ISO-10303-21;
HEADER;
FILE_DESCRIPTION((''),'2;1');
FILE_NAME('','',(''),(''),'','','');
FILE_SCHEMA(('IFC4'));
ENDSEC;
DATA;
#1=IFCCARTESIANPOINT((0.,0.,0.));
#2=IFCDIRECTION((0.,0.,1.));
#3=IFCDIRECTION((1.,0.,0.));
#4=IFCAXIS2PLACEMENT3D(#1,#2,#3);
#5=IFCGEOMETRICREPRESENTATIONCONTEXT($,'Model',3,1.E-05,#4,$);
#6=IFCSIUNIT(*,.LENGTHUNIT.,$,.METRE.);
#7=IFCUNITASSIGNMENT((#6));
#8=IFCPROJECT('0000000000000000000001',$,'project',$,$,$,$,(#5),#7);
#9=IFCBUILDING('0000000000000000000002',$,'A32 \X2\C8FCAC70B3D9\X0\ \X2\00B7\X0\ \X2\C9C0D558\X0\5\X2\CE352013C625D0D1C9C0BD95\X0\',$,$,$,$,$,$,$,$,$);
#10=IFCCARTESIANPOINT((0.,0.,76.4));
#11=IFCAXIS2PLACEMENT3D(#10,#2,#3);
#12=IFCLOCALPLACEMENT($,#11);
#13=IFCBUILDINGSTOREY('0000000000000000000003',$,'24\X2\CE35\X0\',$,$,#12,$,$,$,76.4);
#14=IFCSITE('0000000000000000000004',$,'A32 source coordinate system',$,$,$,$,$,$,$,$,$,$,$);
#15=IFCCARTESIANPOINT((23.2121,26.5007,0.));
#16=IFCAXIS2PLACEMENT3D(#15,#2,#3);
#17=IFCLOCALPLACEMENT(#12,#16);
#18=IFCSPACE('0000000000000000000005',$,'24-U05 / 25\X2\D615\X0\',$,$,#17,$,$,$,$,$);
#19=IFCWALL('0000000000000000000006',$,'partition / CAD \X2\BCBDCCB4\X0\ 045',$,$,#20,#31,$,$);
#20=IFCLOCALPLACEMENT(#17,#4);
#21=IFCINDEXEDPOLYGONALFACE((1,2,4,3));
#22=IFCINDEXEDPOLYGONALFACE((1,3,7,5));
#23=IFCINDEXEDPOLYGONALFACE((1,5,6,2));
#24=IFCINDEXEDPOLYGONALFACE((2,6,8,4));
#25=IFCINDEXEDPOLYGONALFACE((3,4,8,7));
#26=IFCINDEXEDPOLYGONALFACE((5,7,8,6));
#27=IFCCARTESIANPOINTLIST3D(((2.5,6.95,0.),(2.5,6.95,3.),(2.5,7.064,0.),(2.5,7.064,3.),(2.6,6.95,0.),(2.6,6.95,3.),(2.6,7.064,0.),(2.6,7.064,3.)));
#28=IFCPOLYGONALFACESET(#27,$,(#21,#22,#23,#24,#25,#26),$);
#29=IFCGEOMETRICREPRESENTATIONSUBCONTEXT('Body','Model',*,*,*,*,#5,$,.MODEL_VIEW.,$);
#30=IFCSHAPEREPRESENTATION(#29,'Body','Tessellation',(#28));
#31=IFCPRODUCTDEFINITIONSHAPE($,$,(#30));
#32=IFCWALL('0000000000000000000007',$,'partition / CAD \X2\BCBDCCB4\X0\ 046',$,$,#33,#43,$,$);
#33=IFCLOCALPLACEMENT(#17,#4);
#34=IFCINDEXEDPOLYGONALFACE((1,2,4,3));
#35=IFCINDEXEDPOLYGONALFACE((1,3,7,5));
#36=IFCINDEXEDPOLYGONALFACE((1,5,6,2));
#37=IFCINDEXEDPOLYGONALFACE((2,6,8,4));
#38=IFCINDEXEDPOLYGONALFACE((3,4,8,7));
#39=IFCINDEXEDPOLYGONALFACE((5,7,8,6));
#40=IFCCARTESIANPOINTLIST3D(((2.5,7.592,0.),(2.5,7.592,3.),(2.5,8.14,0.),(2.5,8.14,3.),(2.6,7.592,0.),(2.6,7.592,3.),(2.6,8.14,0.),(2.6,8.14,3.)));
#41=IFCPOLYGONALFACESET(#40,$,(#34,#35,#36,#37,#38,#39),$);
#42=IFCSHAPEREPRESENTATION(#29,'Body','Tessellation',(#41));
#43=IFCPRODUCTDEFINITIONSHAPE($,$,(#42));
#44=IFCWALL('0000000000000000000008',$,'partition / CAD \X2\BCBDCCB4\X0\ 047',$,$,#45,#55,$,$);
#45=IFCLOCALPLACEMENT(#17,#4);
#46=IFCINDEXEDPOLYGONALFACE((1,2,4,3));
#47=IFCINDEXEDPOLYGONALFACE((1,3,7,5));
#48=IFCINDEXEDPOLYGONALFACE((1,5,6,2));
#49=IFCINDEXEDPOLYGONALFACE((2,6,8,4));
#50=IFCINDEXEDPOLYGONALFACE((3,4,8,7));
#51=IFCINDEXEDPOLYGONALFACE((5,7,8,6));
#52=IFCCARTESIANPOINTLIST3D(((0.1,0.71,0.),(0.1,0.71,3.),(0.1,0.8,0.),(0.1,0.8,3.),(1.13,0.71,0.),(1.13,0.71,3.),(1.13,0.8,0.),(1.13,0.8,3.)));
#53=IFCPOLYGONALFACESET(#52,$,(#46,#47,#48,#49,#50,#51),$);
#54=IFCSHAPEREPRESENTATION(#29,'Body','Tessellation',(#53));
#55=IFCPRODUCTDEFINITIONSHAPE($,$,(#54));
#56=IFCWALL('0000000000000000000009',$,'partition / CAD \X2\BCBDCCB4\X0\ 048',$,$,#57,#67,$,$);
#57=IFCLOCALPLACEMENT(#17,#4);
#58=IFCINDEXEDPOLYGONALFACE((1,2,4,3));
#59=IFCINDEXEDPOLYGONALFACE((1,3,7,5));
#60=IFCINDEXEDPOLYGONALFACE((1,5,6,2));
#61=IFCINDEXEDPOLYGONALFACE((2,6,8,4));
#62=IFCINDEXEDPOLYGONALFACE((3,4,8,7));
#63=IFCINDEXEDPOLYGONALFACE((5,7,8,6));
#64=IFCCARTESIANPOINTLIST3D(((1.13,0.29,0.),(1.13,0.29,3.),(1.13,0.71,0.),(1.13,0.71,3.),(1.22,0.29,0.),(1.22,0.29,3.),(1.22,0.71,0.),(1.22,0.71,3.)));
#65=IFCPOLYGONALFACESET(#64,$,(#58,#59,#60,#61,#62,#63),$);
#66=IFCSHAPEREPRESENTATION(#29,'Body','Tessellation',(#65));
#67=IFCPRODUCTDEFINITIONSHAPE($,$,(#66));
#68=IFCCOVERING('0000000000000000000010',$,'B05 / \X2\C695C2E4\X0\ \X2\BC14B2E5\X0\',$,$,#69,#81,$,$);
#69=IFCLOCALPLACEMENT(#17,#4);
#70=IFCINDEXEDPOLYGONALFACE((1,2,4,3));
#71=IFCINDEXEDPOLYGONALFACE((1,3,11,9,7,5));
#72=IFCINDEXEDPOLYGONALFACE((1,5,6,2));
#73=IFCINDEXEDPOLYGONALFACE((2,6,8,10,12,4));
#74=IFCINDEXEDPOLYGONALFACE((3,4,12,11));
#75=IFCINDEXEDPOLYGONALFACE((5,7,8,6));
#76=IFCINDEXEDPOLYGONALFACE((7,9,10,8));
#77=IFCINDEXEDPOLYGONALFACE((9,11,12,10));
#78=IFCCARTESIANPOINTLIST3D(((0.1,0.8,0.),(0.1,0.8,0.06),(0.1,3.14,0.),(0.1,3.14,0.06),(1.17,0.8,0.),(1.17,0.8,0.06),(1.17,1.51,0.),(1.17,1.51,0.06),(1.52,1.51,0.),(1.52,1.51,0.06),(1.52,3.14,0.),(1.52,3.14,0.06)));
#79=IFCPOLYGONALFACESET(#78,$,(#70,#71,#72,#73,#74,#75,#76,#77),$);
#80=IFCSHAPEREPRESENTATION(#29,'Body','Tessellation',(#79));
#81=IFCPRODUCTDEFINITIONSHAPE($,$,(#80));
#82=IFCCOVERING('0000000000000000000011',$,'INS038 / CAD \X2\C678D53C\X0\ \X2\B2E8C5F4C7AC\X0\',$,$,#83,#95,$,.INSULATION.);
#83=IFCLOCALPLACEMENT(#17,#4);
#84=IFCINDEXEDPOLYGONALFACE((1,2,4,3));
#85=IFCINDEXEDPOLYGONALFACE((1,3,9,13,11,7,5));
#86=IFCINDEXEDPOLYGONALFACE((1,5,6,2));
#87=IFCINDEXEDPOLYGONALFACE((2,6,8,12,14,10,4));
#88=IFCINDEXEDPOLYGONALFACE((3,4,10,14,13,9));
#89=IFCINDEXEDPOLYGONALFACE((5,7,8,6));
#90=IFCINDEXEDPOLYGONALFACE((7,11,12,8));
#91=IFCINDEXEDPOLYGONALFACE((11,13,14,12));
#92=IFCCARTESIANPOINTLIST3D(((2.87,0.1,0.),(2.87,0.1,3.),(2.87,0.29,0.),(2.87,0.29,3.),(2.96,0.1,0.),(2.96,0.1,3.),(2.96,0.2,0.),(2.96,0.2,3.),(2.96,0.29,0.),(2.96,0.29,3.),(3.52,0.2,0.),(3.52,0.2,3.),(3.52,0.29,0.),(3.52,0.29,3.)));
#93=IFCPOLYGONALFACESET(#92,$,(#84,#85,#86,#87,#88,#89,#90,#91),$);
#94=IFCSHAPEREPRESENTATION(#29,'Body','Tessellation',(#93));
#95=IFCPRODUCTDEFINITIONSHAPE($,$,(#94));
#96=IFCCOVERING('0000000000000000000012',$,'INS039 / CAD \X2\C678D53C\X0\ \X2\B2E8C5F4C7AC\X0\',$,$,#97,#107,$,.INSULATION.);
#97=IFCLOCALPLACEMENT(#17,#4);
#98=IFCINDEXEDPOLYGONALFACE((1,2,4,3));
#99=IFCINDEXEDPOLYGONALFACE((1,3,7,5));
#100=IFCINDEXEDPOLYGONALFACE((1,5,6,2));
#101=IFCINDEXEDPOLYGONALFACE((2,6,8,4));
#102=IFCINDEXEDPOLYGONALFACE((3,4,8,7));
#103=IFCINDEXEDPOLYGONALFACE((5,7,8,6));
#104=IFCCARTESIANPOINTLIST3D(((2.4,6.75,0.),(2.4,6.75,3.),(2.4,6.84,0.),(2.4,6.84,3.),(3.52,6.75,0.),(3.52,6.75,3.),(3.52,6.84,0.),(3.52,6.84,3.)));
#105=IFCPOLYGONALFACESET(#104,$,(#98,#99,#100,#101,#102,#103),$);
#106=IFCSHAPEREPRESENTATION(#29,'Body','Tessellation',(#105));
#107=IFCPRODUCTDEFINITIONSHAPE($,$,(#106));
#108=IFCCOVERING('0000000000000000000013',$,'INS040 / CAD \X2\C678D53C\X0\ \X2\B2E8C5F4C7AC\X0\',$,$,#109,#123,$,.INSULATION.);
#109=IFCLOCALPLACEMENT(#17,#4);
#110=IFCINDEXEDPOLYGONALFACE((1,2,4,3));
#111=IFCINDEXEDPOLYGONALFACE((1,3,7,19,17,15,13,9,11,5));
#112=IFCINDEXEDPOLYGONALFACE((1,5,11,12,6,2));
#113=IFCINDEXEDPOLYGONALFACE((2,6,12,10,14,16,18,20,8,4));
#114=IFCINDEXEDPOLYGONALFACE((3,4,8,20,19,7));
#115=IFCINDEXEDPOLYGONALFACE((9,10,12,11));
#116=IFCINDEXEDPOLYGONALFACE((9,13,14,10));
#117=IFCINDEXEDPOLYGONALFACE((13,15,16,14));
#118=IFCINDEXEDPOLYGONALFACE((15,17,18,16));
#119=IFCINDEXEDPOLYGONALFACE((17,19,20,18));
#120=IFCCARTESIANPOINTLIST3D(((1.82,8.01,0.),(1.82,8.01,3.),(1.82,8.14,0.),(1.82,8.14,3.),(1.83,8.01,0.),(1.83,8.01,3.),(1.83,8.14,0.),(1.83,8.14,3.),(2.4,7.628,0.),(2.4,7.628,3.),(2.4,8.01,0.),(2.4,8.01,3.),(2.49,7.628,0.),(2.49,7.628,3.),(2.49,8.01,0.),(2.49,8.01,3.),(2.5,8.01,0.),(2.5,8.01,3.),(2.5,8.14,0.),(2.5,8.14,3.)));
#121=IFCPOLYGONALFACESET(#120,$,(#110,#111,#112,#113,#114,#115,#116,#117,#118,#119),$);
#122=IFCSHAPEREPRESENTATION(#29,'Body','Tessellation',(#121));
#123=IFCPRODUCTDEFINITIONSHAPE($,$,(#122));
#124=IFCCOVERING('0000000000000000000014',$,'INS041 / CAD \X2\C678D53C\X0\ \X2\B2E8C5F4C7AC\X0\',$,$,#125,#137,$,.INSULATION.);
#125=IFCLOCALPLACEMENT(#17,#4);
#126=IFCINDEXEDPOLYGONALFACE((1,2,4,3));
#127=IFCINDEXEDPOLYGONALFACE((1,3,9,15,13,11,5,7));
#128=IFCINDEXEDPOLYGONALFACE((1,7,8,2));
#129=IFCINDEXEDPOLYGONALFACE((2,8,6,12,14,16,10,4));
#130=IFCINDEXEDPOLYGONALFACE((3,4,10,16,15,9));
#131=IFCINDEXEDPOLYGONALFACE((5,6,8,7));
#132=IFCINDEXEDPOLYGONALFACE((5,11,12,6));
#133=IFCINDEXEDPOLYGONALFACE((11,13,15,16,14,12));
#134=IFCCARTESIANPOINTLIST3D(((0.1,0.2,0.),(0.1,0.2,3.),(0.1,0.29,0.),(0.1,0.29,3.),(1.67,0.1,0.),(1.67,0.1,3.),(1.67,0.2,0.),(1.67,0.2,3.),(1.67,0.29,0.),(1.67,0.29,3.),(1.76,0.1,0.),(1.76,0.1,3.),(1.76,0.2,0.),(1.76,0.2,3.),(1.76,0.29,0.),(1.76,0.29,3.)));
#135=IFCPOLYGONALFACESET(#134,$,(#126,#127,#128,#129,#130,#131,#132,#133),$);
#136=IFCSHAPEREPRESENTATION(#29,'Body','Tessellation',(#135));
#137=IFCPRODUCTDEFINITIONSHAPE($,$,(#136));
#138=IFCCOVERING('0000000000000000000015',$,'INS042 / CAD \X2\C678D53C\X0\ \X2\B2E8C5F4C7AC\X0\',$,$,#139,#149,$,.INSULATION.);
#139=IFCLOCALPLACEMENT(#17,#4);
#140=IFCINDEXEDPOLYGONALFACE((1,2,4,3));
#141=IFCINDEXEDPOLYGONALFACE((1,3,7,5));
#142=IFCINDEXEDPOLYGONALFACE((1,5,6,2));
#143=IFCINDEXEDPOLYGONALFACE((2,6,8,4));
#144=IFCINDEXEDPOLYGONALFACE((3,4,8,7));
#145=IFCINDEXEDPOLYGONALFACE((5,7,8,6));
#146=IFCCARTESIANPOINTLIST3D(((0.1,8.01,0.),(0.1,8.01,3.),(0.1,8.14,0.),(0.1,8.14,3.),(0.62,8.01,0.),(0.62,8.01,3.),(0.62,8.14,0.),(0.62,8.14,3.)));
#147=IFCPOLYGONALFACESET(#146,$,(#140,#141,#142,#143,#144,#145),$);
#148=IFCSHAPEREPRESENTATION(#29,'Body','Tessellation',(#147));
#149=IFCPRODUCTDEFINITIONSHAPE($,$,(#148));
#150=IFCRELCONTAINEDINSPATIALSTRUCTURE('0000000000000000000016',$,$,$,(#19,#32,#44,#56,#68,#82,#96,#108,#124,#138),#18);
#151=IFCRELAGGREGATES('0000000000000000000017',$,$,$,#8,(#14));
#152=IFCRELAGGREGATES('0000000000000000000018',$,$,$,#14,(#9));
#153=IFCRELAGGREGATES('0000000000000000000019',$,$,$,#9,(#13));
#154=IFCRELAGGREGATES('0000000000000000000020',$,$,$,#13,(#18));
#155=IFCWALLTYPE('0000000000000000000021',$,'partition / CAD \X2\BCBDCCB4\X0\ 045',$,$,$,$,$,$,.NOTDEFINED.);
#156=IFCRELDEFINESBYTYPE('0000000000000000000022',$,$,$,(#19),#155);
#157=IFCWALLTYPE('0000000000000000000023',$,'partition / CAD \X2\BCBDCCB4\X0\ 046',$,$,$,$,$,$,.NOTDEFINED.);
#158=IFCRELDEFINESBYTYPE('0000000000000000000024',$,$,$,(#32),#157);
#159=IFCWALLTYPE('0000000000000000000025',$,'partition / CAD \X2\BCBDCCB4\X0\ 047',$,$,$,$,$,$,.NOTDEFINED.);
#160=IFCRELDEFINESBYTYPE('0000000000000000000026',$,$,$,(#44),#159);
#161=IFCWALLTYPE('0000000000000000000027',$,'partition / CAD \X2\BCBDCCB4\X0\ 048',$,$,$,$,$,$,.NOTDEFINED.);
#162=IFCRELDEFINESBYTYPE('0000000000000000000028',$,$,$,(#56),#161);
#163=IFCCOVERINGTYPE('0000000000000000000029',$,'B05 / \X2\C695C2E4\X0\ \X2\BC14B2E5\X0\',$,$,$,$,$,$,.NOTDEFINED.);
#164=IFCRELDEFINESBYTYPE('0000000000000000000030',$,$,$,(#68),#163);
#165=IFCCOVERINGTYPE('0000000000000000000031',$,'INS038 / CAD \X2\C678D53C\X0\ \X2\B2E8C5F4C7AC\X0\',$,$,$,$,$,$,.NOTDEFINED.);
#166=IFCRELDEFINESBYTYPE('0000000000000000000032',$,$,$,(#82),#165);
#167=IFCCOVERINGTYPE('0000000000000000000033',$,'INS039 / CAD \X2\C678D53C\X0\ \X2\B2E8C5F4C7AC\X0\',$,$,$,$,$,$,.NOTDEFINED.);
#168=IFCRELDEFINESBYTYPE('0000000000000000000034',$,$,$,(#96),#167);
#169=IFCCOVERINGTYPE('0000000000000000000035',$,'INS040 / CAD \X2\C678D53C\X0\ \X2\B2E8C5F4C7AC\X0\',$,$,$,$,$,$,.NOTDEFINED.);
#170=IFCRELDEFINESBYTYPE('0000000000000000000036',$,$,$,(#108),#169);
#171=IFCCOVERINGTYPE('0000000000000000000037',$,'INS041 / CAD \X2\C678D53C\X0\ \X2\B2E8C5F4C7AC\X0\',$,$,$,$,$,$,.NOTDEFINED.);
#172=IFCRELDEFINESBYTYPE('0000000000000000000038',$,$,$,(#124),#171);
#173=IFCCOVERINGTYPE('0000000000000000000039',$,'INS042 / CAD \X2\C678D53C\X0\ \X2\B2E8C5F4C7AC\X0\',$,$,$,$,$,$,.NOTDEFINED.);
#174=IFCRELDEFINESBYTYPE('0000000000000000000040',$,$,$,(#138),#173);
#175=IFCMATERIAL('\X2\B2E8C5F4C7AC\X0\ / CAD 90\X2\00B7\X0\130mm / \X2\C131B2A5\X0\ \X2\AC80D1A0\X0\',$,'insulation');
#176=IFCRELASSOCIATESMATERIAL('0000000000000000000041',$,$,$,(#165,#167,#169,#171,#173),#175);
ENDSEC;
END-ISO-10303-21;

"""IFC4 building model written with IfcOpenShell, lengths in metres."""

from ifc_helpers import new_model, si_unit, frame, origin, origin_with_axes, place, context, subcontext, project, spatial, polyline, outline, extrude, source, transform, mapped, material, type_object, type_shapes, element, save


model = new_model("IFC4")

# Units and contexts
model_context = context("Model", 3, precision=1e-05, world=origin_with_axes())
body_context = subcontext(model_context, "Body", "Model", "MODEL_VIEW")
ifc_project = project(units=[si_unit("LENGTHUNIT", "METRE")], contexts=[model_context])

# Site, building, storey, space
storey_placement = place(None, frame((0.0, 0.0, 76.4), z_axis=(0.0, 0.0, 1.0), x_axis=(1.0, 0.0, 0.0)))
space_placement = place(storey_placement, frame((23.2121, 26.5007, 0.0), z_axis=(0.0, 0.0, 1.0), x_axis=(1.0, 0.0, 0.0)))
site = spatial("IfcSite", under=ifc_project, Name="A32 source coordinate system")
building = spatial("IfcBuilding", under=site, Name="A32 주거동 · 지하5층–옥탑지붕")
storey = spatial("IfcBuildingStorey", under=building, at=storey_placement, Name="24층", Elevation=76.4)
space = spatial("IfcSpace", under=storey, at=space_placement, Name="24-U05 / 25형")

# Walls
wall_type_1 = type_object("IfcWallType", Name="partition / CAD 벽체 045", PredefinedType="NOTDEFINED")
shared_shape_1 = source(origin(), body_context, "Body", "SweptSolid", [
    extrude(outline(polyline([(2.5, 7.064), (2.6, 7.064), (2.6, 6.95), (2.5, 6.95), (2.5, 7.064)])), origin(), (0.0, 0.0, 1.0), 3.0),
])
type_shapes(wall_type_1, [shared_shape_1])
wall_1_placement = place(space_placement, origin_with_axes())
element("IfcWall", 1, at=wall_1_placement, inside=space, type_object=wall_type_1, Name="partition / CAD 벽체 045", context=body_context, shape_type="MappedRepresentation", body=[
    mapped(shared_shape_1, transform((0.0, 0.0, 0.0), scale=1.0)),
])
wall_type_2 = type_object("IfcWallType", Name="partition / CAD 벽체 046", PredefinedType="NOTDEFINED")
shared_shape_2 = source(origin(), body_context, "Body", "SweptSolid", [
    extrude(outline(polyline([(2.6, 7.592), (2.5, 7.592), (2.5, 8.14), (2.6, 8.14), (2.6, 7.592)])), origin(), (0.0, 0.0, 1.0), 3.0),
])
type_shapes(wall_type_2, [shared_shape_2])
wall_2_placement = place(space_placement, origin_with_axes())
element("IfcWall", 2, at=wall_2_placement, inside=space, type_object=wall_type_2, Name="partition / CAD 벽체 046", context=body_context, shape_type="MappedRepresentation", body=[
    mapped(shared_shape_2, transform((0.0, 0.0, 0.0), scale=1.0)),
])
wall_type_3 = type_object("IfcWallType", Name="partition / CAD 벽체 047", PredefinedType="NOTDEFINED")
shared_shape_3 = source(origin(), body_context, "Body", "SweptSolid", [
    extrude(outline(polyline([(1.13, 0.71), (0.1, 0.71), (0.1, 0.8), (1.13, 0.8), (1.13, 0.71)])), origin(), (0.0, 0.0, 1.0), 3.0),
])
type_shapes(wall_type_3, [shared_shape_3])
wall_3_placement = place(space_placement, origin_with_axes())
element("IfcWall", 3, at=wall_3_placement, inside=space, type_object=wall_type_3, Name="partition / CAD 벽체 047", context=body_context, shape_type="MappedRepresentation", body=[
    mapped(shared_shape_3, transform((0.0, 0.0, 0.0), scale=1.0)),
])
wall_type_4 = type_object("IfcWallType", Name="partition / CAD 벽체 048", PredefinedType="NOTDEFINED")
shared_shape_4 = source(origin(), body_context, "Body", "SweptSolid", [
    extrude(outline(polyline([(1.22, 0.29), (1.13, 0.29), (1.13, 0.71), (1.22, 0.71), (1.22, 0.29)])), origin(), (0.0, 0.0, 1.0), 3.0),
])
type_shapes(wall_type_4, [shared_shape_4])
wall_4_placement = place(space_placement, origin_with_axes())
element("IfcWall", 4, at=wall_4_placement, inside=space, type_object=wall_type_4, Name="partition / CAD 벽체 048", context=body_context, shape_type="MappedRepresentation", body=[
    mapped(shared_shape_4, transform((0.0, 0.0, 0.0), scale=1.0)),
])

# Coverings
covering_type_1 = type_object("IfcCoveringType", Name="B05 / 욕실 바닥", PredefinedType="NOTDEFINED")
shared_shape_5 = source(origin(), body_context, "Body", "SweptSolid", [
    extrude(outline(polyline([(0.1, 3.14), (1.52, 3.14), (1.52, 1.51), (1.17, 1.51), (1.17, 0.8), (0.1, 0.8), (0.1, 3.14)])), origin(), (0.0, 0.0, 1.0), 0.06),
])
type_shapes(covering_type_1, [shared_shape_5])
covering_1_placement = place(space_placement, origin_with_axes())
element("IfcCovering", 5, at=covering_1_placement, inside=space, type_object=covering_type_1, Name="B05 / 욕실 바닥", context=body_context, shape_type="MappedRepresentation", body=[
    mapped(shared_shape_5, transform((0.0, 0.0, 0.0), scale=1.0)),
])
ifc_material = material(Name="단열재 / CAD 90·130mm / 성능 검토", Category="insulation")
covering_type_2 = type_object("IfcCoveringType", Name="INS038 / CAD 외피 단열재", PredefinedType="NOTDEFINED", material=ifc_material)
shared_shape_6 = source(origin(), body_context, "Body", "SweptSolid", [
    extrude(outline(polyline([(2.96, 0.2), (2.96, 0.1), (2.87, 0.1), (2.87, 0.29), (2.96, 0.29), (3.52, 0.29), (3.52, 0.2), (2.96, 0.2)])), origin(), (0.0, 0.0, 1.0), 3.0),
])
type_shapes(covering_type_2, [shared_shape_6])
covering_2_placement = place(space_placement, origin_with_axes())
element("IfcCovering", 6, at=covering_2_placement, inside=space, type_object=covering_type_2, Name="INS038 / CAD 외피 단열재", PredefinedType="INSULATION", context=body_context, shape_type="MappedRepresentation", body=[
    mapped(shared_shape_6, transform((0.0, 0.0, 0.0), scale=1.0)),
])
covering_type_3 = type_object("IfcCoveringType", Name="INS039 / CAD 외피 단열재", PredefinedType="NOTDEFINED", material=ifc_material)
shared_shape_7 = source(origin(), body_context, "Body", "SweptSolid", [
    extrude(outline(polyline([(2.4, 6.75), (2.4, 6.84), (3.52, 6.84), (3.52, 6.75), (2.4, 6.75)])), origin(), (0.0, 0.0, 1.0), 3.0),
])
type_shapes(covering_type_3, [shared_shape_7])
covering_3_placement = place(space_placement, origin_with_axes())
element("IfcCovering", 7, at=covering_3_placement, inside=space, type_object=covering_type_3, Name="INS039 / CAD 외피 단열재", PredefinedType="INSULATION", context=body_context, shape_type="MappedRepresentation", body=[
    mapped(shared_shape_7, transform((0.0, 0.0, 0.0), scale=1.0)),
])
covering_type_4 = type_object("IfcCoveringType", Name="INS040 / CAD 외피 단열재", PredefinedType="NOTDEFINED", material=ifc_material)
shared_shape_8 = source(origin(), body_context, "Body", "SweptSolid", [
    extrude(outline(polyline([(2.4, 7.628), (2.4, 8.01), (1.83, 8.01), (1.82, 8.01), (1.82, 8.14), (1.83, 8.14), (2.5, 8.14), (2.5, 8.01), (2.49, 8.01), (2.49, 7.628), (2.4, 7.628)])), origin(), (0.0, 0.0, 1.0), 3.0),
])
type_shapes(covering_type_4, [shared_shape_8])
covering_4_placement = place(space_placement, origin_with_axes())
element("IfcCovering", 8, at=covering_4_placement, inside=space, type_object=covering_type_4, Name="INS040 / CAD 외피 단열재", PredefinedType="INSULATION", context=body_context, shape_type="MappedRepresentation", body=[
    mapped(shared_shape_8, transform((0.0, 0.0, 0.0), scale=1.0)),
])
covering_type_5 = type_object("IfcCoveringType", Name="INS041 / CAD 외피 단열재", PredefinedType="NOTDEFINED", material=ifc_material)
shared_shape_9 = source(origin(), body_context, "Body", "SweptSolid", [
    extrude(outline(polyline([(1.67, 0.2), (0.1, 0.2), (0.1, 0.29), (1.67, 0.29), (1.76, 0.29), (1.76, 0.2), (1.76, 0.1), (1.67, 0.1), (1.67, 0.2)])), origin(), (0.0, 0.0, 1.0), 3.0),
])
type_shapes(covering_type_5, [shared_shape_9])
covering_5_placement = place(space_placement, origin_with_axes())
element("IfcCovering", 9, at=covering_5_placement, inside=space, type_object=covering_type_5, Name="INS041 / CAD 외피 단열재", PredefinedType="INSULATION", context=body_context, shape_type="MappedRepresentation", body=[
    mapped(shared_shape_9, transform((0.0, 0.0, 0.0), scale=1.0)),
])
covering_type_6 = type_object("IfcCoveringType", Name="INS042 / CAD 외피 단열재", PredefinedType="NOTDEFINED", material=ifc_material)
shared_shape_10 = source(origin(), body_context, "Body", "SweptSolid", [
    extrude(outline(polyline([(0.62, 8.14), (0.62, 8.01), (0.1, 8.01), (0.1, 8.14), (0.62, 8.14)])), origin(), (0.0, 0.0, 1.0), 3.0),
])
type_shapes(covering_type_6, [shared_shape_10])
covering_6_placement = place(space_placement, origin_with_axes())
element("IfcCovering", 10, at=covering_6_placement, inside=space, type_object=covering_type_6, Name="INS042 / CAD 외피 단열재", PredefinedType="INSULATION", context=body_context, shape_type="MappedRepresentation", body=[
    mapped(shared_shape_10, transform((0.0, 0.0, 0.0), scale=1.0)),
])

save(model, "model.ifc")
